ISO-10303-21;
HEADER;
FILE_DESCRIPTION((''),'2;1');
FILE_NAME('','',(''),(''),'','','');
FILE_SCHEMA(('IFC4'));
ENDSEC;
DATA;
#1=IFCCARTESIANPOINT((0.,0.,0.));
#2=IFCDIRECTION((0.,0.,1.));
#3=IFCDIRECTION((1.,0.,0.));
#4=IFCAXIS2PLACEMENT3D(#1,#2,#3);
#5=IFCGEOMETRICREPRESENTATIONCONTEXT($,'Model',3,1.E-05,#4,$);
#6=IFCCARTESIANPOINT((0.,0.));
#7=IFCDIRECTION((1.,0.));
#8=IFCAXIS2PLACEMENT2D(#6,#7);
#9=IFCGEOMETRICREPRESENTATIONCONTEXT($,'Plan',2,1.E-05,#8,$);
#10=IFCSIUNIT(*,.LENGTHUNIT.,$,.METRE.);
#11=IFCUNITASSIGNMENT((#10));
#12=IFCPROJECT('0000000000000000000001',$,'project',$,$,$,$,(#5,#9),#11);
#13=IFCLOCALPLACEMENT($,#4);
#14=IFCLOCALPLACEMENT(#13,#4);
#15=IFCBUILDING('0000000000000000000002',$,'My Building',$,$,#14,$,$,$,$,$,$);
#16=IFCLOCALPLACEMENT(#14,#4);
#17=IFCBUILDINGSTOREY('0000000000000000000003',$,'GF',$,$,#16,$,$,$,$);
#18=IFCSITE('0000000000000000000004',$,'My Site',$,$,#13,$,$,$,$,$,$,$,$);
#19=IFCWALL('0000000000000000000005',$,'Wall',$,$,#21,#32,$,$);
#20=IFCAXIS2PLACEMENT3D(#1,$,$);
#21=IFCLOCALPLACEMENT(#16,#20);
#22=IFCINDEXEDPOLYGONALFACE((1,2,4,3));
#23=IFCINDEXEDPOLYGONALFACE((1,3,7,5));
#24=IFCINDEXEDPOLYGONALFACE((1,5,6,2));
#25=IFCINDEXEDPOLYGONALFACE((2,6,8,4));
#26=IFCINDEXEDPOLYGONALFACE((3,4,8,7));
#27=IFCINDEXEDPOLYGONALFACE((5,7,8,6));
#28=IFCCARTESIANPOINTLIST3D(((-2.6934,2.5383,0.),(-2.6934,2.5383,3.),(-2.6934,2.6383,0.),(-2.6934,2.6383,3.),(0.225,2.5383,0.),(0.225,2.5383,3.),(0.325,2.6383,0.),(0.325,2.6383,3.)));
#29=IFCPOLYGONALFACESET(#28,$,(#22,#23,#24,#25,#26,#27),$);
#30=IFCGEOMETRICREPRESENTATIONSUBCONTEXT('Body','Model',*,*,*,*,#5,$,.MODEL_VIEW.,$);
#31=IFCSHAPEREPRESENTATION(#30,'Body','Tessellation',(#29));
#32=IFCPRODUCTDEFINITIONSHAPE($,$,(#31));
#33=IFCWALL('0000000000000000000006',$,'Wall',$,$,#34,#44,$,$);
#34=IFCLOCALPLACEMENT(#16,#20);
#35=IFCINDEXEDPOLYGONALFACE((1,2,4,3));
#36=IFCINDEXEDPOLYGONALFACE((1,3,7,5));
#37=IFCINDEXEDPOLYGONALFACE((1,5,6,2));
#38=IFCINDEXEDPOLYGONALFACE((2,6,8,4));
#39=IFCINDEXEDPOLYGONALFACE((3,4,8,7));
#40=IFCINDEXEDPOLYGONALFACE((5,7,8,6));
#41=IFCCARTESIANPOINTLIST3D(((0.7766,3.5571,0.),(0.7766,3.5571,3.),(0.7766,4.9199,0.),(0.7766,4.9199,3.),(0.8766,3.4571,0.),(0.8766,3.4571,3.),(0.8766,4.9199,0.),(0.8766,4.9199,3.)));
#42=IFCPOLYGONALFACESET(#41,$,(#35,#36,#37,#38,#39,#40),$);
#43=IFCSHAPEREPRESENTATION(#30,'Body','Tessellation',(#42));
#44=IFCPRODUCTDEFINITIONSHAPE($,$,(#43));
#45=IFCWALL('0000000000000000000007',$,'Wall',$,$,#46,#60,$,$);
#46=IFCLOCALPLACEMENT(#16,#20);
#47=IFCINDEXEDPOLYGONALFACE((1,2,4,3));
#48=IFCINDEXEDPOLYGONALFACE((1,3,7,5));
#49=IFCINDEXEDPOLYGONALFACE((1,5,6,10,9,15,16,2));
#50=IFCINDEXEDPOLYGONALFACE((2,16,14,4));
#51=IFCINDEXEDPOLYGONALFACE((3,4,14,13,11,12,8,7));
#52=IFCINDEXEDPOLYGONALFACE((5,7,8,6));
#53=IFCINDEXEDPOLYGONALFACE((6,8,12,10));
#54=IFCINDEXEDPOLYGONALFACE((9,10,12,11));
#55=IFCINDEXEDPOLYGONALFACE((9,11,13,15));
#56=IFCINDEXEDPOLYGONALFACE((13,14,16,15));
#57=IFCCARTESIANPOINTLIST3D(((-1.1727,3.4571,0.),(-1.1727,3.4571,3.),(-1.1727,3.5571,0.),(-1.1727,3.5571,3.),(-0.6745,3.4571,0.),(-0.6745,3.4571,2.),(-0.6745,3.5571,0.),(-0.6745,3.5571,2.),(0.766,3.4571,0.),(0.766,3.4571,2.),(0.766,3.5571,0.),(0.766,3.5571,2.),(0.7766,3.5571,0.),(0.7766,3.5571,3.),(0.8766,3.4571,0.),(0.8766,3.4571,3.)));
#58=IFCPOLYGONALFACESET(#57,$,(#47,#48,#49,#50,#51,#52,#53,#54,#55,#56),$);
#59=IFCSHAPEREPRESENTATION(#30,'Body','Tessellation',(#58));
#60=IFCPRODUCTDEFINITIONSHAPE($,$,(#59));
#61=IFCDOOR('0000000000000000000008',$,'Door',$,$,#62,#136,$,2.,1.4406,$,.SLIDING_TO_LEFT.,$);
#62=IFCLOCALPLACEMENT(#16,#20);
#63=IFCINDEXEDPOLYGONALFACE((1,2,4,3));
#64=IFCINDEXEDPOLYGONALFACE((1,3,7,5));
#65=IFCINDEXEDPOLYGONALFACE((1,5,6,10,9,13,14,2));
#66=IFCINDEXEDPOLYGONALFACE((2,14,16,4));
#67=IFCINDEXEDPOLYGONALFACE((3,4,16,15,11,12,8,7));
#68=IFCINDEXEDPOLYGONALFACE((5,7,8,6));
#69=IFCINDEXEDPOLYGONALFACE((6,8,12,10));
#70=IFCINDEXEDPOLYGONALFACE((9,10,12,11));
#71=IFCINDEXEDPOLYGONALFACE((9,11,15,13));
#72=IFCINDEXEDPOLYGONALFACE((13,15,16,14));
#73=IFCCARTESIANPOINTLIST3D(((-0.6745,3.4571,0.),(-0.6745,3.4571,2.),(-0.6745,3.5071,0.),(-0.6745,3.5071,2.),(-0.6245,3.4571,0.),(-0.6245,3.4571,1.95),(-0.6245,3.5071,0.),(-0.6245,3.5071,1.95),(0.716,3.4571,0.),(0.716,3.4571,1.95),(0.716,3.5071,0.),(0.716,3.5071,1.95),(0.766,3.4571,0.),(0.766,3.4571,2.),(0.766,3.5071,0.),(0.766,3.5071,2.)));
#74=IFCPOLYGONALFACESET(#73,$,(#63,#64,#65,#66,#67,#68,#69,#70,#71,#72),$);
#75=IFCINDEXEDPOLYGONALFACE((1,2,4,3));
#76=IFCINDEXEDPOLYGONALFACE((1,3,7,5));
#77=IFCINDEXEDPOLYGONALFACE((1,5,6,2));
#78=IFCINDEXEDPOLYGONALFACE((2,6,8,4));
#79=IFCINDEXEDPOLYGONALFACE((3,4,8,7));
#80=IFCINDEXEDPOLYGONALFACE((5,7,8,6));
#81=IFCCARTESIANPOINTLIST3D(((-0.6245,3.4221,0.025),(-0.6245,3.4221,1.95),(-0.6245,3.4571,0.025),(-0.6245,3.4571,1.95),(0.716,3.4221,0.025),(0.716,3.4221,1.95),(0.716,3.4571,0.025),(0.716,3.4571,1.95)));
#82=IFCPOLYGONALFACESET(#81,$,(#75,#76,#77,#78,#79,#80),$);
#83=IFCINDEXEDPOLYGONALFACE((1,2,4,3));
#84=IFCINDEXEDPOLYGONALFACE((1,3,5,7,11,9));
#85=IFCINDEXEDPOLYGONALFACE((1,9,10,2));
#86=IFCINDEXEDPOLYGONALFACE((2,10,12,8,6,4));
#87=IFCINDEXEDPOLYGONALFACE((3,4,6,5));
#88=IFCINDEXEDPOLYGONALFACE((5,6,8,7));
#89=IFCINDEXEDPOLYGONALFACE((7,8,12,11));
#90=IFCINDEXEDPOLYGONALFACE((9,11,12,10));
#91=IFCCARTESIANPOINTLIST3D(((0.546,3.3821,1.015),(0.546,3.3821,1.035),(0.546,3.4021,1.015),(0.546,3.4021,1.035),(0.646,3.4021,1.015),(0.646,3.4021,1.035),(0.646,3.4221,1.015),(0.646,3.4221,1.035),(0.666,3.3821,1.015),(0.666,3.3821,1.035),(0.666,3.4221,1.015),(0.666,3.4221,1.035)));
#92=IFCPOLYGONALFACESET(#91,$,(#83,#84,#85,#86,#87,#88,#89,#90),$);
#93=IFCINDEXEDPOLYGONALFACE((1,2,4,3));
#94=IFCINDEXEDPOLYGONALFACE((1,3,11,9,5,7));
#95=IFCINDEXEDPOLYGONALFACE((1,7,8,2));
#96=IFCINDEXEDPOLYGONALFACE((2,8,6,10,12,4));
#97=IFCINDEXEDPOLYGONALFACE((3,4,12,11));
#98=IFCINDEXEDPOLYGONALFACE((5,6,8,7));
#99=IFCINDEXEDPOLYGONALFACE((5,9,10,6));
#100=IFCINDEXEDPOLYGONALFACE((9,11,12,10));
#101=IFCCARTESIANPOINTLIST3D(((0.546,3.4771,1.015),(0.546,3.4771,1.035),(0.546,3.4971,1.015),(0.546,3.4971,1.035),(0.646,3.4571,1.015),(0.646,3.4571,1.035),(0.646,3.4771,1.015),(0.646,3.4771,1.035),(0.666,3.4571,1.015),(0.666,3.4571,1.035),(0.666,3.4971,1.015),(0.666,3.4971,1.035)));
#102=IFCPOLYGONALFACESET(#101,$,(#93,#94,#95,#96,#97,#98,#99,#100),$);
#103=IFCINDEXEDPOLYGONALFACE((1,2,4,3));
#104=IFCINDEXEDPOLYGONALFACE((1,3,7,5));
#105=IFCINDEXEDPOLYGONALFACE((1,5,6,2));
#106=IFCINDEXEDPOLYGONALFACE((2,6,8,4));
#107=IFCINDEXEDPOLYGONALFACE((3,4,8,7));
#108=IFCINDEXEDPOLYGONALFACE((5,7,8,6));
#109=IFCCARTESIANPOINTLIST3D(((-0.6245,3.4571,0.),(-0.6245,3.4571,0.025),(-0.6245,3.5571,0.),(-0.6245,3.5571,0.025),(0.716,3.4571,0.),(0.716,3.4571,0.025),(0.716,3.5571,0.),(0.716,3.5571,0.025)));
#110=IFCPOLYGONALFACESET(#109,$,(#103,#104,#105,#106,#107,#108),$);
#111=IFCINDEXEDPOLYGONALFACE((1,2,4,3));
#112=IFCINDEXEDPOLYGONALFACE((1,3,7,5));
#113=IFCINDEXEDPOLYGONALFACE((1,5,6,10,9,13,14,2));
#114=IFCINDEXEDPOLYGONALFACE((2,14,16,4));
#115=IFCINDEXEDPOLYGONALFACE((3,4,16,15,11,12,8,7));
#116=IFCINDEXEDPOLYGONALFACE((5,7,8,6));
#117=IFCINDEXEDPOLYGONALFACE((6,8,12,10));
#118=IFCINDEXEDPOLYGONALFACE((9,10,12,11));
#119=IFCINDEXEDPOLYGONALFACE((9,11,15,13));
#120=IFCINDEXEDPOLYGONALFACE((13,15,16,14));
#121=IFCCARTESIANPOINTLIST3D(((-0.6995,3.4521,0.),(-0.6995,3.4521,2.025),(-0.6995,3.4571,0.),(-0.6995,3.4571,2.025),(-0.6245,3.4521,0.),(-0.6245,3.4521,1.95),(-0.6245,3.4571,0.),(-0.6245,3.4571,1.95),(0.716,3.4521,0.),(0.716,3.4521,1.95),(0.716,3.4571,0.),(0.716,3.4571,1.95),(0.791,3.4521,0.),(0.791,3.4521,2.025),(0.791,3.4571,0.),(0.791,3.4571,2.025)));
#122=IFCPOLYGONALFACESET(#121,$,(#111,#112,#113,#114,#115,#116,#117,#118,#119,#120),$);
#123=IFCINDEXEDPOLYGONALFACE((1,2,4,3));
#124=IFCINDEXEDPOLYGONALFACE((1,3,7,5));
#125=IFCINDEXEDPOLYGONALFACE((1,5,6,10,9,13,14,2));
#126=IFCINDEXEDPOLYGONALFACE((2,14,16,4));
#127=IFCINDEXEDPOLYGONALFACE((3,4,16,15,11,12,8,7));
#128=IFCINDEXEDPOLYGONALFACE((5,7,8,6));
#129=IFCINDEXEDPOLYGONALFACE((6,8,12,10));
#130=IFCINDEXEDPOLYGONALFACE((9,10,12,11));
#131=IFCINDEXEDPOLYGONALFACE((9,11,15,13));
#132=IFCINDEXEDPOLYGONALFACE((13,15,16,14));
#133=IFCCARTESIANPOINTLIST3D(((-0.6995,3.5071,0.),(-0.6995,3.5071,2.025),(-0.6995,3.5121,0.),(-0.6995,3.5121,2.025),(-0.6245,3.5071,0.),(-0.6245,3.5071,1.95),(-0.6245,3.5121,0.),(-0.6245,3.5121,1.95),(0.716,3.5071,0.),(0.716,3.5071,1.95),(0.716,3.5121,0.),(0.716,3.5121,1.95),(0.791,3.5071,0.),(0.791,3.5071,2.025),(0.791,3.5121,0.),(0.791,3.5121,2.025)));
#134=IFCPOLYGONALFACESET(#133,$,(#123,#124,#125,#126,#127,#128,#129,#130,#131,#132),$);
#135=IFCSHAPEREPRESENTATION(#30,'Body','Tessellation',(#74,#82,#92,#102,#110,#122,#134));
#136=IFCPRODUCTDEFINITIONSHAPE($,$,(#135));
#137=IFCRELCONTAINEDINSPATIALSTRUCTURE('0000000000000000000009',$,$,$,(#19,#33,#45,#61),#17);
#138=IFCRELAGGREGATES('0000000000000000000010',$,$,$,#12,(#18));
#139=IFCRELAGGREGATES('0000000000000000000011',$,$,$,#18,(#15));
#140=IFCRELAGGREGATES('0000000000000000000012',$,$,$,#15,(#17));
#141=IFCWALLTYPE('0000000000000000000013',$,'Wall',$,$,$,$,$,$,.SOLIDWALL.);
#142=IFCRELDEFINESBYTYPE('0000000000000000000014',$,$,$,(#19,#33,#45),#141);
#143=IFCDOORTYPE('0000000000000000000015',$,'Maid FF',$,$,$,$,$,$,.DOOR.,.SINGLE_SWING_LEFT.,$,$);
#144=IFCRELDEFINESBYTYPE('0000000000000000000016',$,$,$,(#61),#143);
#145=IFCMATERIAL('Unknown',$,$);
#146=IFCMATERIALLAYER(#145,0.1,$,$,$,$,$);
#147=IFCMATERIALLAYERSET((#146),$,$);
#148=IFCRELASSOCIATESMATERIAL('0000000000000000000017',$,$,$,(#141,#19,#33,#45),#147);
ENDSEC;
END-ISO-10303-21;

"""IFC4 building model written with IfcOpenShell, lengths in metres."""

from ifc_helpers import new_model, entity, si_unit, frame, origin_with_axes, origin_2d_with_axis, place, context, subcontext, project, spatial, line, indexed_curve, outline, extrude, shape, source, transform, mapped, material, layer, layer_set, layer_usage, type_object, type_shapes, element, fill, save


model = new_model("IFC4")

# Units and contexts
model_context = context("Model", 3, precision=1e-05, world=origin_with_axes())
plan_context = context("Plan", 2, precision=1e-05, world=origin_2d_with_axis())
body_context_1 = subcontext(model_context, "Body", "Model", "MODEL_VIEW")
body_context_2 = subcontext(plan_context, "Body", "Plan", "PLAN_VIEW")
ifc_project = project(units=[si_unit("LENGTHUNIT", "METRE")], contexts=[model_context, plan_context])

# Site, building, storey
site_placement = place(None, origin_with_axes())
site = spatial("IfcSite", under=ifc_project, at=site_placement, Name="My Site")
building_placement = place(site_placement, origin_with_axes())
building = spatial("IfcBuilding", under=site, at=building_placement, Name="My Building")
storey_placement = place(building_placement, origin_with_axes())
storey = spatial("IfcBuildingStorey", under=building, at=storey_placement, Name="GF")

# Shared definitions
ifc_material = material(Name="Unknown")

# Shared definitions
ifc_layer = layer(ifc_material, 0.1)
ifc_layer_set = layer_set([ifc_layer])
wall_type = type_object("IfcWallType", Name="Wall", PredefinedType="SOLIDWALL", material=ifc_layer_set)

# Walls
ifc_layer_usage_1 = layer_usage(ifc_layer_set, "AXIS2", "POSITIVE", 0.0)
wall_1_placement = place(storey_placement, frame((0.325, 2.6383, 0.0), z_axis=(0.0, 0.0, 1.0), x_axis=(-1.0, 0.0, 0.0)))
element("IfcWall", 1, at=wall_1_placement, inside=storey, type_object=wall_type, material=ifc_layer_usage_1, Name="Wall", context=body_context_1, shape_type="SweptSolid", body=[
    extrude(outline(indexed_curve([(0.0, 0.0), (0.1, 0.1), (3.0184, 0.1), (3.0184, 0.0)], segments=[line(1, 2, 3, 4, 1)])), origin_with_axes(), (0.0, 0.0, 1.0), 3.0),
])
ifc_layer_usage_2 = layer_usage(ifc_layer_set, "AXIS2", "POSITIVE", 0.0)
wall_2_placement = place(storey_placement, frame((0.7766, 5.0199, 0.0), z_axis=(0.0, 0.0, 1.0), x_axis=(0.0, -1.0, 0.0)))
element("IfcWall", 2, at=wall_2_placement, inside=storey, type_object=wall_type, material=ifc_layer_usage_2, Name="Wall", context=body_context_1, shape_type="SweptSolid", body=[
    extrude(outline(indexed_curve([(0.1, 0.0), (0.1, 0.1), (1.5628, 0.1), (1.4628, 0.0)], segments=[line(1, 2, 3, 4, 1)])), origin_with_axes(), (0.0, 0.0, 1.0), 3.0),
])

# Wall, opening, door
ifc_layer_usage_3 = layer_usage(ifc_layer_set, "AXIS2", "POSITIVE", 0.0)
wall_3_placement = place(storey_placement, frame((0.7766, 3.5571, 0.0), z_axis=(0.0, 0.0, 1.0), x_axis=(-1.0, 0.0, 0.0)))
wall_3 = element("IfcWall", 3, at=wall_3_placement, inside=storey, type_object=wall_type, material=ifc_layer_usage_3, Name="Wall", context=body_context_1, shape_type="SweptSolid", body=[
    extrude(outline(indexed_curve([(0.0, 0.0), (-0.1, 0.1), (1.9493, 0.1), (1.9493, 0.0)], segments=[line(1, 2, 3, 4, 1)])), origin_with_axes(), (0.0, 0.0, 1.0), 3.0),
])
shared_shape_1 = source(origin_with_axes(), body_context_1, "Body", "SweptSolid", [
    extrude(outline(indexed_curve([(0.0, 0.0), (1.4406, 0.0), (1.4406, 2.0), (0.0, 2.0)], segments=[line(1, 2, 3, 4, 1)])), frame((0.0, -0.6, 0.0), z_axis=(0.0, -1.0, 0.0), x_axis=(1.0, 0.0, 0.0)), (0.0, 0.0, -1.0), 1.2),
])
opening_1_placement = place(wall_3_placement, frame((1.4511, 0.1, 0.0), z_axis=(0.0, 0.0, 1.0), x_axis=(-1.0, 0.000001, 0.0)))
opening_1 = element("IfcOpeningElement", 4, at=opening_1_placement, cuts=wall_3, PredefinedType="OPENING", context=body_context_1, shape_type="MappedRepresentation", body=[
    mapped(shared_shape_1, transform((0.0, 0.0, 0.0), x_axis=(1.0, 0.0, 0.0), y_axis=(0.0, 1.0, 0.0), z_axis=(0.0, 0.0, 1.0), scale=1.0)),
])
door_type = type_object("IfcDoorType", Name="Maid FF", OperationType="SINGLE_SWING_LEFT", PredefinedType="DOOR")
shared_shape_2 = source(origin_with_axes(), body_context_1, "Body", "SweptSolid", [
    extrude(outline(indexed_curve([(0.0, 0.0), (0.0, 2.0), (1.4406, 2.0), (1.4406, 0.0), (1.3906, 0.0), (1.3906, 1.95), (0.05, 1.95), (0.05, 0.0)], segments=[line(1, 2, 3, 4, 5, 6, 7, 8, 1)])), frame((0.0, 0.0, 0.0), z_axis=(0.0, -1.0, 0.0), x_axis=(1.0, 0.0, 0.0)), (0.0, 0.0, -1.0), 0.05),
    extrude(outline(indexed_curve([(0.0, 0.0), (1.3406, 0.0), (1.3406, 0.035), (0.0, 0.035)], segments=[line(1, 2, 3, 4, 1)])), frame((0.05, -0.035, 0.025), z_axis=(0.0, 0.0, 1.0), x_axis=(1.0, 0.0, 0.0)), (0.0, 0.0, 1.0), 1.925),
    extrude(outline(indexed_curve([(0.0, 0.0), (0.0, -0.04), (-0.12, -0.04), (-0.12, -0.02), (-0.02, -0.02), (-0.02, 0.0)], segments=[line(1, 2, 3, 4, 5, 6, 1)])), frame((1.3406, -0.035, 1.015), z_axis=(0.0, 0.0, 1.0), x_axis=(1.0, 0.0, 0.0)), (0.0, 0.0, 1.0), 0.02),
    extrude(outline(indexed_curve([(0.0, 0.0), (0.0, 0.04), (-0.12, 0.04), (-0.12, 0.02), (-0.02, 0.02), (-0.02, 0.0)], segments=[line(1, 2, 3, 4, 5, 6, 1)])), frame((1.3406, 0.0, 1.015), z_axis=(0.0, 0.0, 1.0), x_axis=(1.0, 0.0, 0.0)), (0.0, 0.0, 1.0), 0.02),
    extrude(outline(indexed_curve([(0.0, 0.0), (1.3406, 0.0), (1.3406, 0.1), (0.0, 0.1)], segments=[line(1, 2, 3, 4, 1)])), frame((0.05, 0.0, 0.0), z_axis=(0.0, 0.0, 1.0), x_axis=(1.0, 0.0, 0.0)), (0.0, 0.0, 1.0), 0.025),
    extrude(outline(indexed_curve([(0.0, 0.0), (0.0, 2.025), (1.4906, 2.025), (1.4906, 0.0), (1.4156, 0.0), (1.4156, 1.95), (0.075, 1.95), (0.075, 0.0)], segments=[line(1, 2, 3, 4, 5, 6, 7, 8, 1)])), frame((-0.025, -0.005, 0.0), z_axis=(0.0, -1.0, 0.0), x_axis=(1.0, 0.0, 0.0)), (0.0, 0.0, -1.0), 0.005),
    extrude(outline(indexed_curve([(0.0, 0.0), (0.0, 2.025), (1.4906, 2.025), (1.4906, 0.0), (1.4156, 0.0), (1.4156, 1.95), (0.075, 1.95), (0.075, 0.0)], segments=[line(1, 2, 3, 4, 5, 6, 7, 8, 1)])), frame((-0.025, 0.05, 0.0), z_axis=(0.0, -1.0, 0.0), x_axis=(1.0, 0.0, 0.0)), (0.0, 0.0, -1.0), 0.005),
])
shared_shape_3 = source(origin_with_axes(), body_context_2, "Body", "Curve2D", [
    entity("IfcIndexedPolyCurve", entity("IfcCartesianPointList2D", [[0.0, 0.0], [0.05, 0.0], [0.05, 0.05], [0.0, 0.05]]), [entity("IfcLineIndex", [1, 2, 3, 4, 1])]),
    entity("IfcIndexedPolyCurve", entity("IfcCartesianPointList2D", [[1.4406, 0.0], [1.3906, 0.0], [1.3906, 0.05], [1.4406, 0.05]]), [entity("IfcLineIndex", [1, 2, 3, 4, 1])]),
    entity("IfcIndexedPolyCurve", entity("IfcCartesianPointList2D", [[-0.6203, -0.035], [0.7203, -0.035], [0.7203, 0.0], [-0.6203, 0.0]]), [entity("IfcLineIndex", [1, 2, 3, 4, 1])]),
])
type_shapes(door_type, [shared_shape_2, shared_shape_3])
door_placement = place(opening_1_placement, frame((0.0, 0.0, 0.0), z_axis=(0.0, 0.0, 1.0), x_axis=(1.0, 0.0, 0.0)))
door = element("IfcDoor", 5, at=door_placement, inside=storey, type_object=door_type, Name="Door", OperationType="SLIDING_TO_LEFT", OverallHeight=2.0, OverallWidth=1.4406, shapes=[
    shape(body_context_1, "Body", "MappedRepresentation", [mapped(shared_shape_2, transform((0.0, 0.0, 0.0), x_axis=(1.0, 0.0, 0.0), y_axis=(0.0, 1.0, 0.0), z_axis=(0.0, 0.0, 1.0), scale=1.0))]),
    shape(body_context_2, "Body", "MappedRepresentation", [mapped(shared_shape_3, transform((0.0, 0.0, 0.0), x_axis=(1.0, 0.0, 0.0), y_axis=(0.0, 1.0, 0.0), z_axis=(0.0, 0.0, 1.0), scale=1.0))]),
])
fill(opening_1, door)

save(model, "model.ifc")
